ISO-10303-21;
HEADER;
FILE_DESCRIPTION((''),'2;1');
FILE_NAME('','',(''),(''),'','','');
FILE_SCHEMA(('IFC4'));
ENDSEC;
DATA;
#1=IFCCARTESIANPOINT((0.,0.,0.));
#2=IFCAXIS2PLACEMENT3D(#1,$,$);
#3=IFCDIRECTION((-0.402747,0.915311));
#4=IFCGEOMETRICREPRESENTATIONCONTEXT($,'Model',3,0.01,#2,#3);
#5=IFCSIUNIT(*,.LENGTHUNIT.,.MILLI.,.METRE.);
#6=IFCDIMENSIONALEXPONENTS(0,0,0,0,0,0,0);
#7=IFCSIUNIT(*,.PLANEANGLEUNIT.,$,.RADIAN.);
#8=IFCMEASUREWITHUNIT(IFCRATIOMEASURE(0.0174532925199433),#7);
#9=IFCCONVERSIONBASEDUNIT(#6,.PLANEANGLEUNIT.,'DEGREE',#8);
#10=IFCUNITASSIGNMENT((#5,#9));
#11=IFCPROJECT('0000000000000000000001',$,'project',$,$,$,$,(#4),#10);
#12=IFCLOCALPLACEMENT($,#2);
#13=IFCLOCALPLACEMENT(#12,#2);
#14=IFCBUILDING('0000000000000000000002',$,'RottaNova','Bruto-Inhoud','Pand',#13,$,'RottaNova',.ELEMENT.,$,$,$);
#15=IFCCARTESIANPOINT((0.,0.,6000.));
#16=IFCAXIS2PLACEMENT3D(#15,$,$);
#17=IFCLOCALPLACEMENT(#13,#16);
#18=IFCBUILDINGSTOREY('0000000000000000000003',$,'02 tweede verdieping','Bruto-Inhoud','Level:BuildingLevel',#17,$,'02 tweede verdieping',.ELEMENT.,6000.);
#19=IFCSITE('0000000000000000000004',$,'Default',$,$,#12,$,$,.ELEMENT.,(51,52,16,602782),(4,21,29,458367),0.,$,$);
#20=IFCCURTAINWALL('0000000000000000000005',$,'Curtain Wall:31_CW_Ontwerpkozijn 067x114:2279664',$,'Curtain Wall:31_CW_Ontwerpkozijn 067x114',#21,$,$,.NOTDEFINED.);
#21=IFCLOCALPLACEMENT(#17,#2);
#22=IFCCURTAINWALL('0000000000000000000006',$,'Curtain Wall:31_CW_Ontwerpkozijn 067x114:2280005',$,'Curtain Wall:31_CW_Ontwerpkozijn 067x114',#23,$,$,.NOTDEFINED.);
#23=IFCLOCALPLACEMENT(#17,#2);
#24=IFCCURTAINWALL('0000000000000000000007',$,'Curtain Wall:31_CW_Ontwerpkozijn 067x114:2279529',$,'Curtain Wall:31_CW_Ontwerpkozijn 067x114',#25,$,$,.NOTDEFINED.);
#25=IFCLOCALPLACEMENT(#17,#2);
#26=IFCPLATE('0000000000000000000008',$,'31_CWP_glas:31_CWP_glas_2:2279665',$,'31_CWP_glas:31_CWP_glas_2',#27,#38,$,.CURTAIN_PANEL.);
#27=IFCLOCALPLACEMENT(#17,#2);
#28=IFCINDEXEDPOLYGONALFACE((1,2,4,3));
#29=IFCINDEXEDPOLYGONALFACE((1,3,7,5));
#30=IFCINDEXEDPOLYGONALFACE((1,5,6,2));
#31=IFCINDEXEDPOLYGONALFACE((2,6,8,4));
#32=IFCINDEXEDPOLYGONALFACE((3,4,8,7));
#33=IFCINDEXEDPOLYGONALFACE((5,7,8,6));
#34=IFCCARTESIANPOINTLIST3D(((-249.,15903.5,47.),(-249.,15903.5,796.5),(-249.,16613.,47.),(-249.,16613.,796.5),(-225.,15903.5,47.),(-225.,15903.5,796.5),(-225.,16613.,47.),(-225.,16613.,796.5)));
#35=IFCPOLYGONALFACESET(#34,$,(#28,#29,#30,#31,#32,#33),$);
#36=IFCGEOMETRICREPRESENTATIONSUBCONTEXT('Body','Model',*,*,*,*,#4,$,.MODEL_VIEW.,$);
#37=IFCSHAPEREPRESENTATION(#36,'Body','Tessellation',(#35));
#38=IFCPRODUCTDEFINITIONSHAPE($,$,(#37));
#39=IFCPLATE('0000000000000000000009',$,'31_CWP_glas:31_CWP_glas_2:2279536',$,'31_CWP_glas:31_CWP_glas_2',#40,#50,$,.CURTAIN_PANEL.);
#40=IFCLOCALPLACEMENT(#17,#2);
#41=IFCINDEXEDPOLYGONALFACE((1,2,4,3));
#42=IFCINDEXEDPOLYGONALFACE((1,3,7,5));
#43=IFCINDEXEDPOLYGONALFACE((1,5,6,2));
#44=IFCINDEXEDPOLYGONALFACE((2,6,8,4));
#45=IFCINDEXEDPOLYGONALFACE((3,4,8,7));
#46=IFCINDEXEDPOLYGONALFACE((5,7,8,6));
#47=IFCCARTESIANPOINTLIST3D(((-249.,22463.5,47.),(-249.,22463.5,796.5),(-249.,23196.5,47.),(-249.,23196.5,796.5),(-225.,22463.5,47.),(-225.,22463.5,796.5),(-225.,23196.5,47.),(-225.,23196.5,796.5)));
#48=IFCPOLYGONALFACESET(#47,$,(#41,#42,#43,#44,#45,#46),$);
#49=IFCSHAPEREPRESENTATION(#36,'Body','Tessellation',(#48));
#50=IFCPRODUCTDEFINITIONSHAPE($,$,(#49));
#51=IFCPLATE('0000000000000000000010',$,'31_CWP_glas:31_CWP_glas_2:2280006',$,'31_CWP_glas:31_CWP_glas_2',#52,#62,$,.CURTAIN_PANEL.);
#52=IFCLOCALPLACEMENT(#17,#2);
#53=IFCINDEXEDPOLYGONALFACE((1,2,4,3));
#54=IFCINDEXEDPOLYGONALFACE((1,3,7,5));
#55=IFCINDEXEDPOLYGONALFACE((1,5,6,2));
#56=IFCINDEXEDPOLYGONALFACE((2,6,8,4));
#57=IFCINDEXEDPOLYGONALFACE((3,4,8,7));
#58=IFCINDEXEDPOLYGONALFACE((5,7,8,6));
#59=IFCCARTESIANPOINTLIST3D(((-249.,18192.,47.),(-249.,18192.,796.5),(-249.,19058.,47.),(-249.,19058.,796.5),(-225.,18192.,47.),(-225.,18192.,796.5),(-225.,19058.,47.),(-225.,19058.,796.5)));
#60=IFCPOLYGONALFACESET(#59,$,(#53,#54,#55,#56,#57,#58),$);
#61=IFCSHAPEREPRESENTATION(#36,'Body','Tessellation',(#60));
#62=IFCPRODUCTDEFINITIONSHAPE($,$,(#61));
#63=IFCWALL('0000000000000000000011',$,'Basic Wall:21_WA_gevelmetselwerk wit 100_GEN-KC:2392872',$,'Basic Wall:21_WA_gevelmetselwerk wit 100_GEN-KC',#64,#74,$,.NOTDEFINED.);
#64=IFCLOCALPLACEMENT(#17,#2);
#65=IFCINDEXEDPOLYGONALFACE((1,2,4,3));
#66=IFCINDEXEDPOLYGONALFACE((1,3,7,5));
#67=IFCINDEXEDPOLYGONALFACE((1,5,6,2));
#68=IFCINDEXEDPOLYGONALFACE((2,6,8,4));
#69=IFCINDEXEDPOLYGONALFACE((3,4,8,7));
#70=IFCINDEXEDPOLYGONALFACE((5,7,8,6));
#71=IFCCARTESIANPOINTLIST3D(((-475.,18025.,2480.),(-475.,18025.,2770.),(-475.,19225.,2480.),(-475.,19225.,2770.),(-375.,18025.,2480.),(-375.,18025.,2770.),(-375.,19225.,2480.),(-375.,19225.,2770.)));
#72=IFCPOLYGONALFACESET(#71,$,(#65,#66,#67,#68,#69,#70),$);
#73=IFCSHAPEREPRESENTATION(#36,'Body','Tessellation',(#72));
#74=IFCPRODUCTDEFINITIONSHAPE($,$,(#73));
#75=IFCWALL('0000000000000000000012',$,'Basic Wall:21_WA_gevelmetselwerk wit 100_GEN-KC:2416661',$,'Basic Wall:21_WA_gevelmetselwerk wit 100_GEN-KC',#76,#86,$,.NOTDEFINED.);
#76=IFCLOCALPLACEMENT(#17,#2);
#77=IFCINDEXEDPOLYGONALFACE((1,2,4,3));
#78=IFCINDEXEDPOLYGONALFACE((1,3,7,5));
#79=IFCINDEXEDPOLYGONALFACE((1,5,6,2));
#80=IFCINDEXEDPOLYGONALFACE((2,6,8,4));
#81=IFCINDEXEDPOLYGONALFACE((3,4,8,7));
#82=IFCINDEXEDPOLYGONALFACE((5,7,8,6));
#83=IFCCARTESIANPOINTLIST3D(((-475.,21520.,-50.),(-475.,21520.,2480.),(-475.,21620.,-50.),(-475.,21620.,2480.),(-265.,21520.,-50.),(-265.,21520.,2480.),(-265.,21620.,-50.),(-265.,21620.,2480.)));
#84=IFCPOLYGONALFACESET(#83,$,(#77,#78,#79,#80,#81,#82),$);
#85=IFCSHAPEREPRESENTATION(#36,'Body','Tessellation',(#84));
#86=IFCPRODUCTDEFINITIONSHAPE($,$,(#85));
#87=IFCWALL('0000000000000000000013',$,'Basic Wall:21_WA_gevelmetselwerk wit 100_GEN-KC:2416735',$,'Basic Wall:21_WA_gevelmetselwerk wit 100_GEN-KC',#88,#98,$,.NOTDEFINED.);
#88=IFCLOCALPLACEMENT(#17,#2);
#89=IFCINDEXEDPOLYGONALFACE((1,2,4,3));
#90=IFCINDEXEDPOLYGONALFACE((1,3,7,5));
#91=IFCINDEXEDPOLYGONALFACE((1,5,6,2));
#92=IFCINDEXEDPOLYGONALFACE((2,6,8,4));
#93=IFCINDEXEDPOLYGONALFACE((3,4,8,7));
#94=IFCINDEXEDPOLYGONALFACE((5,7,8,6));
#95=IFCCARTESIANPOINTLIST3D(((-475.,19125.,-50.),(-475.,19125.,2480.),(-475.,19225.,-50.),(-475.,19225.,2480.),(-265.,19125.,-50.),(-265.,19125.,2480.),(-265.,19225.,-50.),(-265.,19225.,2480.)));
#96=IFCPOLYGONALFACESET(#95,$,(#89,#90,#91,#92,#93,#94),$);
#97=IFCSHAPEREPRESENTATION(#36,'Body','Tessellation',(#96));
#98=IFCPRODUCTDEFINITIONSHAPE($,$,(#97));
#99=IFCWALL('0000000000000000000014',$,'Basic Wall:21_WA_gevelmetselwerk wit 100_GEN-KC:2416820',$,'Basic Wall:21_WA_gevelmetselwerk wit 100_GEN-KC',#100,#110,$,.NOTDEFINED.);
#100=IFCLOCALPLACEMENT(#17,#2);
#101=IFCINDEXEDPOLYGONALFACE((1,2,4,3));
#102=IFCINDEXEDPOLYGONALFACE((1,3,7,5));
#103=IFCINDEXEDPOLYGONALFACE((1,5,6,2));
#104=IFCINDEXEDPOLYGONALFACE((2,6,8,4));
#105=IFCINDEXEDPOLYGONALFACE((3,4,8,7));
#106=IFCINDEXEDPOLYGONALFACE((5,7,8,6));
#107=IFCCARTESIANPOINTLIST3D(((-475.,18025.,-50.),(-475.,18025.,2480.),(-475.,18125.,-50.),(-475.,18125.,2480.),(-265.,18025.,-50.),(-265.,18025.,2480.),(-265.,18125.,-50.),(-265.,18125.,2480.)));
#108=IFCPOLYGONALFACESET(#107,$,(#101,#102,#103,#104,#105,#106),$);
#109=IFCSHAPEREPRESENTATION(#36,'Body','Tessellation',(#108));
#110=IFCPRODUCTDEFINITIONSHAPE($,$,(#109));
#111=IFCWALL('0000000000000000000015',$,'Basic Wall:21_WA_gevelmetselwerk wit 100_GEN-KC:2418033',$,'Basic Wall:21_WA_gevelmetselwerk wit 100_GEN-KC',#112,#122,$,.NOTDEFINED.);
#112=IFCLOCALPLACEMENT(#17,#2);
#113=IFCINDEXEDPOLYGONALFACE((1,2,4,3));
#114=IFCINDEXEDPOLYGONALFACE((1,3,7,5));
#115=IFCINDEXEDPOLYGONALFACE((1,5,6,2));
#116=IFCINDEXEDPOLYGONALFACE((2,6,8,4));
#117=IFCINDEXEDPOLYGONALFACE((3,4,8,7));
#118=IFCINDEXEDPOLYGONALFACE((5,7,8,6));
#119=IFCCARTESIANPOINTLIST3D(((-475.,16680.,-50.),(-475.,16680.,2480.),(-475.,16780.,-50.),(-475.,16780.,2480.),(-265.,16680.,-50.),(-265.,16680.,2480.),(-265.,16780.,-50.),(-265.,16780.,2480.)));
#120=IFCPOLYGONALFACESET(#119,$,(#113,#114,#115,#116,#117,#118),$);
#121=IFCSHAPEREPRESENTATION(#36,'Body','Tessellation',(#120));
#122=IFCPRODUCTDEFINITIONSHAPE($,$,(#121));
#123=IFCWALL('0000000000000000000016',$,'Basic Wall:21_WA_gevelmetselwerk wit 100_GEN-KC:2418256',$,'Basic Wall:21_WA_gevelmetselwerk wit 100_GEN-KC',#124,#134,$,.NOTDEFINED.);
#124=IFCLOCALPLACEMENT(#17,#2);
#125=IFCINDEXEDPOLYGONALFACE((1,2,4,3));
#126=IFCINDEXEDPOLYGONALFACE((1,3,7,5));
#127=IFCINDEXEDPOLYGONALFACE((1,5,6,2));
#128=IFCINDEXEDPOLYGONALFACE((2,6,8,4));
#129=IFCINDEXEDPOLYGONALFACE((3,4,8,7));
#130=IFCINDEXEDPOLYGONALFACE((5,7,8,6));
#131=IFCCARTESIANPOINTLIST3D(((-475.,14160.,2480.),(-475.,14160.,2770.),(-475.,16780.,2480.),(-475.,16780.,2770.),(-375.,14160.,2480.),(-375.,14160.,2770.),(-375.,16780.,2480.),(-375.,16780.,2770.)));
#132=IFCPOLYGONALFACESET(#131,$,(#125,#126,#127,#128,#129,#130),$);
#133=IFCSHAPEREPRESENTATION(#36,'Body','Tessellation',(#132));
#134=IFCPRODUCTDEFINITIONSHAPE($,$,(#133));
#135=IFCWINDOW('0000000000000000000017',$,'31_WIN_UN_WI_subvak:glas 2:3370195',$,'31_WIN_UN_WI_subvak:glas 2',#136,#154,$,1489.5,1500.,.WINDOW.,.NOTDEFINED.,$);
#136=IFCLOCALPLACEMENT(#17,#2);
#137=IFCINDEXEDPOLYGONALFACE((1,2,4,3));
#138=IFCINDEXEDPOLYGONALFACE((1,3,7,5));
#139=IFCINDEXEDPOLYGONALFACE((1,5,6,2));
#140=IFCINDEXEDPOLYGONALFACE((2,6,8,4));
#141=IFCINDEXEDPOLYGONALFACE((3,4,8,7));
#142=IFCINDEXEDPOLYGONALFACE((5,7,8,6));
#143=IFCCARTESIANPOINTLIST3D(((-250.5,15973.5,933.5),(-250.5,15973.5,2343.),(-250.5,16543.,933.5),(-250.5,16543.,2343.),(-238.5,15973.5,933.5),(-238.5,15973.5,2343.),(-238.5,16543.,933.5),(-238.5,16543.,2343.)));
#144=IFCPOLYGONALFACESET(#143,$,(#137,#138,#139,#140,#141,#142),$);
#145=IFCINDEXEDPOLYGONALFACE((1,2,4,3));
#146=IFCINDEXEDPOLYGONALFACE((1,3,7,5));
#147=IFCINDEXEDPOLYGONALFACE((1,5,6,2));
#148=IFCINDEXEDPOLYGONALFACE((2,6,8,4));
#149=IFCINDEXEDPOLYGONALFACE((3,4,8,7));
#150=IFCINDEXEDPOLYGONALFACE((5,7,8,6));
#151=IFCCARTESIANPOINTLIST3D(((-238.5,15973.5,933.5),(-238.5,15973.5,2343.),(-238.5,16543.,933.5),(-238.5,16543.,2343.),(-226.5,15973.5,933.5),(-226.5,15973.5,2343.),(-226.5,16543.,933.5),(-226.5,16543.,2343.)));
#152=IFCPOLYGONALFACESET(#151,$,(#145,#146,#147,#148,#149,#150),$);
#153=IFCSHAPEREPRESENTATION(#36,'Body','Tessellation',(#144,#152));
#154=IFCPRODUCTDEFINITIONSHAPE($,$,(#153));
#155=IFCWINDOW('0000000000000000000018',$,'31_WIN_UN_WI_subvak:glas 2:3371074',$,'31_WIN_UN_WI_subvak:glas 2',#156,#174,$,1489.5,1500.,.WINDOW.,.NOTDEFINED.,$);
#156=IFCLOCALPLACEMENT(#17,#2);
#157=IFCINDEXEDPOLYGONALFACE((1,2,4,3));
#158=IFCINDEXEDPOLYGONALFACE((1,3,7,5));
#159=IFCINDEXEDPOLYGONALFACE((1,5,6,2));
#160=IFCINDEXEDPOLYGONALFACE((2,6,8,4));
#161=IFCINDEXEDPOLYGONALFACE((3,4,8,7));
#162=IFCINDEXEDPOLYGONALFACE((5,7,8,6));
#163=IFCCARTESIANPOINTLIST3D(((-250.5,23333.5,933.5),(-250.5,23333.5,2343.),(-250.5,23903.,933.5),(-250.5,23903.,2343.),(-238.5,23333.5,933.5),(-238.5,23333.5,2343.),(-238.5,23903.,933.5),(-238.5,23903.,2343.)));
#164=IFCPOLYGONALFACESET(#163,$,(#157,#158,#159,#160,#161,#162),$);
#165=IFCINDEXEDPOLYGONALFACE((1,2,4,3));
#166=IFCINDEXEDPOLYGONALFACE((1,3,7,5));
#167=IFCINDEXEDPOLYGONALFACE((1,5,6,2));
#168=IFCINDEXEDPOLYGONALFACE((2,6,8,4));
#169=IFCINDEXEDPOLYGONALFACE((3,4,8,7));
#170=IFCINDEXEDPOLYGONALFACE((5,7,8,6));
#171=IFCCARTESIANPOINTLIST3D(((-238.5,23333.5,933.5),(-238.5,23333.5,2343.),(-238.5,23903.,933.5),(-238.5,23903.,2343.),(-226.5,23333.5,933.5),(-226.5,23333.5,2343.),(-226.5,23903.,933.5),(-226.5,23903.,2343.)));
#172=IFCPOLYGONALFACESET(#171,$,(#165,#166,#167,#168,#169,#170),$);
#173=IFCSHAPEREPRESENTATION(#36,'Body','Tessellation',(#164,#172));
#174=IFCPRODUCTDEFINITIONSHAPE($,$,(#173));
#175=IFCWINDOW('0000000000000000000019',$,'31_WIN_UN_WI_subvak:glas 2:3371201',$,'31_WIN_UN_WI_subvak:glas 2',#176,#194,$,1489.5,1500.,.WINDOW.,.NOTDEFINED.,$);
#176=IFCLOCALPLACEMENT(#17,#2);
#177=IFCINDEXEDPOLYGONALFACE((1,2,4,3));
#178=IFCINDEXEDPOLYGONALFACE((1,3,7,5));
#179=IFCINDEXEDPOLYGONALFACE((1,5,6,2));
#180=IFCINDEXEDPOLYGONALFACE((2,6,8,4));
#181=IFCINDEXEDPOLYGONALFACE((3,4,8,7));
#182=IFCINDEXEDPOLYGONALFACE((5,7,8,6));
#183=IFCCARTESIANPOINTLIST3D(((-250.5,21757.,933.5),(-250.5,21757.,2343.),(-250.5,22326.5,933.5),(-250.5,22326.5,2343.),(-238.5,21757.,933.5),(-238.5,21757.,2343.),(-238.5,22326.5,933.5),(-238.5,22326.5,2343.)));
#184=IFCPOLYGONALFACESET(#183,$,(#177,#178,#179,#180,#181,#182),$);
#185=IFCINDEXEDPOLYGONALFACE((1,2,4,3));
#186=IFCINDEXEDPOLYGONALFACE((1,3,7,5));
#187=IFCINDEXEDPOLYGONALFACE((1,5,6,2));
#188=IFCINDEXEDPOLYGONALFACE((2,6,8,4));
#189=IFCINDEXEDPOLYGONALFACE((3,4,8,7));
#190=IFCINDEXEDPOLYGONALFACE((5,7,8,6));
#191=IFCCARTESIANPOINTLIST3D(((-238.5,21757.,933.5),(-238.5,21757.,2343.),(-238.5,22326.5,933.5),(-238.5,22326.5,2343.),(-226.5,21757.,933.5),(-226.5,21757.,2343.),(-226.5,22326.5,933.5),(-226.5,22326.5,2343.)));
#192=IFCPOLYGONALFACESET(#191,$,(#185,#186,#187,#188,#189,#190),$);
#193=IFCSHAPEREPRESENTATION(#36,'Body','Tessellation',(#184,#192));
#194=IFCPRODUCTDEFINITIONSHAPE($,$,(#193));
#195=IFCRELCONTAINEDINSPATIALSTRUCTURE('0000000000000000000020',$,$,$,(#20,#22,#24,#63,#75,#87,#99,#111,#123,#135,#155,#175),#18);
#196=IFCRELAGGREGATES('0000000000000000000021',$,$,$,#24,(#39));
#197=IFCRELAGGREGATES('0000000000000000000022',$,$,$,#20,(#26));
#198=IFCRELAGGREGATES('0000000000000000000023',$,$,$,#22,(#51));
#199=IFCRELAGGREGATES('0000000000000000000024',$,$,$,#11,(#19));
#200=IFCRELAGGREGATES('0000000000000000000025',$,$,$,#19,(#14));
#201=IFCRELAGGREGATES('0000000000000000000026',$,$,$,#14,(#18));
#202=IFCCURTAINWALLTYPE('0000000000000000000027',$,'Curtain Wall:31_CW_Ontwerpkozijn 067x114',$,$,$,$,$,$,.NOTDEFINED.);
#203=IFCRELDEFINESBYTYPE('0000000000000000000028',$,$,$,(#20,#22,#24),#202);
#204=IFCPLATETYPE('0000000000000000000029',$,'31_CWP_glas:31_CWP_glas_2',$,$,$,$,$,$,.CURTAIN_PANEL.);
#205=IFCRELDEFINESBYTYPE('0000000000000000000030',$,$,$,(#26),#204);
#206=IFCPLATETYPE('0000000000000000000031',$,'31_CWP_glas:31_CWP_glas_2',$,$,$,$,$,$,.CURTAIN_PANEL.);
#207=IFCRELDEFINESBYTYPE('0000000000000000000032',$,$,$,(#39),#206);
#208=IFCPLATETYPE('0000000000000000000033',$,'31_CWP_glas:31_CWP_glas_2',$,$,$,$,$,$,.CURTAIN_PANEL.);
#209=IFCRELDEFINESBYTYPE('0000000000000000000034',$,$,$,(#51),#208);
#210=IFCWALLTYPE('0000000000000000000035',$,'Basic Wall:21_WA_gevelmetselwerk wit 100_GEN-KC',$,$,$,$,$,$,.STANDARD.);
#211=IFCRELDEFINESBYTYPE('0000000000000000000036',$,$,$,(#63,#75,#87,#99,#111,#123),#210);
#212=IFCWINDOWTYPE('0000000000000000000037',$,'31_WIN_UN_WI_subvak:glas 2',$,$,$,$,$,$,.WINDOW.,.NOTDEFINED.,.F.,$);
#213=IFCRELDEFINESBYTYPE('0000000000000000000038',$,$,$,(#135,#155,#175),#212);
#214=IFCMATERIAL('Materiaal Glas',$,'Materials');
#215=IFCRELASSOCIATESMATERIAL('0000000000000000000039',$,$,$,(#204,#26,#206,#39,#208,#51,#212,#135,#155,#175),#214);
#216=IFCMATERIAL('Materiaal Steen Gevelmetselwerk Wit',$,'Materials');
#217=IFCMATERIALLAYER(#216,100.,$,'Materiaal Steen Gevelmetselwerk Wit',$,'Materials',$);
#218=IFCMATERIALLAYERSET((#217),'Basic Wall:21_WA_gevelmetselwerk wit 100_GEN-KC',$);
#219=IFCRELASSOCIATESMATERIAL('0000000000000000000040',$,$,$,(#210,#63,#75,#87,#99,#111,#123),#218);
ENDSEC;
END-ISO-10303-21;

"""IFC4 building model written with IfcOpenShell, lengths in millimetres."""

from ifc_helpers import new_model, entity, si_unit, converted_unit, direction, frame, frame_2d, origin, origin_2d_with_axis, place, context, subcontext, project, spatial, rectangle, extrude, source, transform, mapped, material, layer, layer_set, type_object, type_shapes, element, aggregate, save


model = new_model("IFC4")

# Units and contexts
model_context = context("Model", 3, precision=0.01, world=origin(), true_north=direction((-0.402747, 0.915311)))
body_context = subcontext(model_context, "Body", "Model", "MODEL_VIEW")
ifc_project = project(units=[si_unit("LENGTHUNIT", "METRE", prefix="MILLI"), converted_unit("PLANEANGLEUNIT", "DEGREE", entity("IfcRatioMeasure", 0.0174532925199433), si_unit("PLANEANGLEUNIT", "RADIAN"), dimensions=[0, 0, 0, 0, 0, 0, 0])], contexts=[model_context])

# Site, building, storey
site_placement = place(None, origin())
site = spatial("IfcSite", under=ifc_project, at=site_placement, Name="Default", CompositionType="ELEMENT", RefLatitude=(51, 52, 16, 602782), RefLongitude=(4, 21, 29, 458367), RefElevation=0.0)
building_placement = place(site_placement, origin())
building = spatial("IfcBuilding", under=site, at=building_placement, Name="RottaNova", Description="Bruto-Inhoud", ObjectType="Pand", LongName="RottaNova", CompositionType="ELEMENT")
storey_placement = place(building_placement, frame((0.0, 0.0, 6000.0)))
storey = spatial("IfcBuildingStorey", under=building, at=storey_placement, Name="02 tweede verdieping", Description="Bruto-Inhoud", ObjectType="Level:BuildingLevel", LongName="02 tweede verdieping", CompositionType="ELEMENT", Elevation=6000.0)

# Curtain walls
curtain_wall_type = type_object("IfcCurtainWallType", Name="Curtain Wall:31_CW_Ontwerpkozijn 067x114", PredefinedType="NOTDEFINED")
curtain_wall_1_placement = place(storey_placement, frame((0.0, 0.0, -6000.0)))
curtain_wall_1 = element("IfcCurtainWall", 1, at=curtain_wall_1_placement, inside=storey, type_object=curtain_wall_type, Name="Curtain Wall:31_CW_Ontwerpkozijn 067x114:2279664", ObjectType="Curtain Wall:31_CW_Ontwerpkozijn 067x114", PredefinedType="NOTDEFINED")
curtain_wall_2_placement = place(storey_placement, frame((0.0, 0.0, -6000.0)))
curtain_wall_2 = element("IfcCurtainWall", 2, at=curtain_wall_2_placement, inside=storey, type_object=curtain_wall_type, Name="Curtain Wall:31_CW_Ontwerpkozijn 067x114:2280005", ObjectType="Curtain Wall:31_CW_Ontwerpkozijn 067x114", PredefinedType="NOTDEFINED")

# Curtain wall
curtain_wall_3_placement = place(storey_placement, frame((0.0, 0.0, -6000.0)))
curtain_wall_3 = element("IfcCurtainWall", 3, at=curtain_wall_3_placement, inside=storey, type_object=curtain_wall_type, Name="Curtain Wall:31_CW_Ontwerpkozijn 067x114:2279529", ObjectType="Curtain Wall:31_CW_Ontwerpkozijn 067x114", PredefinedType="NOTDEFINED")
ifc_material_1 = material(Name="Materiaal Glas", Category="Materials")
plate_type_1 = type_object("IfcPlateType", Name="31_CWP_glas:31_CWP_glas_2", PredefinedType="CURTAIN_PANEL", material=ifc_material_1)
shared_shape_1 = source(origin(), body_context, "Body", "SweptSolid", [
    extrude(rectangle(XDim=24.0, YDim=709.5, at=frame_2d((0.0, 0.0), x_axis=(1.0, 0.0))), frame((354.8, 12.0, 0.0), z_axis=(0.0, 0.0, 1.0), x_axis=(0.0, 1.0, 0.0)), (0.0, 0.0, 1.0), 749.5),
])
type_shapes(plate_type_1, [shared_shape_1])

# Plates
plate_1_placement = place(curtain_wall_1_placement, frame((-249.0, 16613.0, 6047.0), z_axis=(0.0, 0.0, 1.0), x_axis=(0.0, -1.0, 0.0)))
plate_1 = element("IfcPlate", 4, at=plate_1_placement, type_object=plate_type_1, material=ifc_material_1, Name="31_CWP_glas:31_CWP_glas_2:2279665", ObjectType="31_CWP_glas:31_CWP_glas_2", PredefinedType="CURTAIN_PANEL", context=body_context, shape_type="MappedRepresentation", body=[
    mapped(shared_shape_1, transform((0.0, 0.0, 0.0), scale=1.0)),
])
plate_type_2 = type_object("IfcPlateType", Name="31_CWP_glas:31_CWP_glas_2", PredefinedType="CURTAIN_PANEL", material=ifc_material_1)
shared_shape_2 = source(origin(), body_context, "Body", "SweptSolid", [
    extrude(rectangle(XDim=24.0, YDim=733.0, at=frame_2d((0.0, 0.0), x_axis=(1.0, 0.0))), frame((366.5, 12.0, 0.0), z_axis=(0.0, 0.0, 1.0), x_axis=(0.0, 1.0, 0.0)), (0.0, 0.0, 1.0), 749.5),
])
type_shapes(plate_type_2, [shared_shape_2])
plate_2_placement = place(curtain_wall_3_placement, frame((-249.0, 23196.5, 6047.0), z_axis=(0.0, 0.0, 1.0), x_axis=(0.0, -1.0, 0.0)))
plate_2 = element("IfcPlate", 5, at=plate_2_placement, type_object=plate_type_2, material=ifc_material_1, Name="31_CWP_glas:31_CWP_glas_2:2279536", ObjectType="31_CWP_glas:31_CWP_glas_2", PredefinedType="CURTAIN_PANEL", context=body_context, shape_type="MappedRepresentation", body=[
    mapped(shared_shape_2, transform((0.0, 0.0, 0.0), scale=1.0)),
])
aggregate(curtain_wall_3, [plate_2])
plate_type_3 = type_object("IfcPlateType", Name="31_CWP_glas:31_CWP_glas_2", PredefinedType="CURTAIN_PANEL", material=ifc_material_1)
shared_shape_3 = source(origin(), body_context, "Body", "SweptSolid", [
    extrude(rectangle(XDim=24.0, YDim=866.0, at=frame_2d((0.0, 0.0), x_axis=(1.0, 0.0))), frame((433.0, 12.0, 0.0), z_axis=(0.0, 0.0, 1.0), x_axis=(0.0, 1.0, 0.0)), (0.0, 0.0, 1.0), 749.5),
])
type_shapes(plate_type_3, [shared_shape_3])
plate_3_placement = place(curtain_wall_2_placement, frame((-225.0, 18192.0, 6047.0), z_axis=(0.0, 0.0, 1.0), x_axis=(0.0, 1.0, 0.0)))
plate_3 = element("IfcPlate", 6, at=plate_3_placement, type_object=plate_type_3, material=ifc_material_1, Name="31_CWP_glas:31_CWP_glas_2:2280006", ObjectType="31_CWP_glas:31_CWP_glas_2", PredefinedType="CURTAIN_PANEL", context=body_context, shape_type="MappedRepresentation", body=[
    mapped(shared_shape_3, transform((0.0, 0.0, 0.0), scale=1.0)),
])

# Shared definitions
ifc_material_2 = material(Name="Materiaal Steen Gevelmetselwerk Wit", Category="Materials")
ifc_layer = layer(ifc_material_2, 100.0, Name="Materiaal Steen Gevelmetselwerk Wit", Category="Materials")
ifc_layer_set = layer_set([ifc_layer], Name="Basic Wall:21_WA_gevelmetselwerk wit 100_GEN-KC")
wall_type = type_object("IfcWallType", Name="Basic Wall:21_WA_gevelmetselwerk wit 100_GEN-KC", PredefinedType="STANDARD", material=ifc_layer_set)

# Walls
wall_1_placement = place(storey_placement, frame((-425.0, 19225.0, 2480.0), z_axis=(0.0, 0.0, 1.0), x_axis=(0.0, -1.0, 0.0)))
element("IfcWall", 7, at=wall_1_placement, inside=storey, type_object=wall_type, material=ifc_layer_set, Name="Basic Wall:21_WA_gevelmetselwerk wit 100_GEN-KC:2392872", ObjectType="Basic Wall:21_WA_gevelmetselwerk wit 100_GEN-KC", PredefinedType="NOTDEFINED", context=body_context, shape_type="SweptSolid", body=[
    extrude(rectangle(XDim=1200.0, YDim=100.0, at=frame_2d((600.0, 0.0), x_axis=(-1.0, 0.0))), origin(), (0.0, 0.0, 1.0), 290.0),
])
wall_2_placement = place(storey_placement, frame((-265.0, 21570.0, -50.0), z_axis=(0.0, 0.0, 1.0), x_axis=(-1.0, 0.0, 0.0)))
element("IfcWall", 8, at=wall_2_placement, inside=storey, type_object=wall_type, material=ifc_layer_set, Name="Basic Wall:21_WA_gevelmetselwerk wit 100_GEN-KC:2416661", ObjectType="Basic Wall:21_WA_gevelmetselwerk wit 100_GEN-KC", PredefinedType="NOTDEFINED", context=body_context, shape_type="SweptSolid", body=[
    extrude(rectangle(XDim=210.0, YDim=100.0, at=frame_2d((105.0, 0.0), x_axis=(-1.0, 0.0))), origin(), (0.0, 0.0, 1.0), 2530.0),
])
wall_3_placement = place(storey_placement, frame((-265.0, 19175.0, -50.0), z_axis=(0.0, 0.0, 1.0), x_axis=(-1.0, 0.0, 0.0)))
element("IfcWall", 9, at=wall_3_placement, inside=storey, type_object=wall_type, material=ifc_layer_set, Name="Basic Wall:21_WA_gevelmetselwerk wit 100_GEN-KC:2416735", ObjectType="Basic Wall:21_WA_gevelmetselwerk wit 100_GEN-KC", PredefinedType="NOTDEFINED", context=body_context, shape_type="SweptSolid", body=[
    extrude(rectangle(XDim=210.0, YDim=100.0, at=frame_2d((105.0, 0.0), x_axis=(-1.0, 0.0))), origin(), (0.0, 0.0, 1.0), 2530.0),
])
wall_4_placement = place(storey_placement, frame((-265.0, 18075.0, -50.0), z_axis=(0.0, 0.0, 1.0), x_axis=(-1.0, 0.0, 0.0)))
element("IfcWall", 10, at=wall_4_placement, inside=storey, type_object=wall_type, material=ifc_layer_set, Name="Basic Wall:21_WA_gevelmetselwerk wit 100_GEN-KC:2416820", ObjectType="Basic Wall:21_WA_gevelmetselwerk wit 100_GEN-KC", PredefinedType="NOTDEFINED", context=body_context, shape_type="SweptSolid", body=[
    extrude(rectangle(XDim=210.0, YDim=100.0, at=frame_2d((105.0, 0.0), x_axis=(-1.0, 0.0))), origin(), (0.0, 0.0, 1.0), 2530.0),
])
wall_5_placement = place(storey_placement, frame((-265.0, 16730.0, -50.0), z_axis=(0.0, 0.0, 1.0), x_axis=(-1.0, 0.0, 0.0)))
element("IfcWall", 11, at=wall_5_placement, inside=storey, type_object=wall_type, material=ifc_layer_set, Name="Basic Wall:21_WA_gevelmetselwerk wit 100_GEN-KC:2418033", ObjectType="Basic Wall:21_WA_gevelmetselwerk wit 100_GEN-KC", PredefinedType="NOTDEFINED", context=body_context, shape_type="SweptSolid", body=[
    extrude(rectangle(XDim=210.0, YDim=100.0, at=frame_2d((105.0, 0.0), x_axis=(-1.0, 0.0))), origin(), (0.0, 0.0, 1.0), 2530.0),
])
wall_6_placement = place(storey_placement, frame((-425.0, 16780.0, 2480.0), z_axis=(0.0, 0.0, 1.0), x_axis=(0.0, -1.0, 0.0)))
element("IfcWall", 12, at=wall_6_placement, inside=storey, type_object=wall_type, material=ifc_layer_set, Name="Basic Wall:21_WA_gevelmetselwerk wit 100_GEN-KC:2418256", ObjectType="Basic Wall:21_WA_gevelmetselwerk wit 100_GEN-KC", PredefinedType="NOTDEFINED", context=body_context, shape_type="SweptSolid", body=[
    extrude(rectangle(XDim=2620.0, YDim=100.0, at=frame_2d((1310.0, 0.0), x_axis=(-1.0, 0.0))), origin(), (0.0, 0.0, 1.0), 290.0),
])

# Windows
window_type_1 = type_object("IfcWindowType", Name="31_WIN_UN_WI_subvak:glas 2", ParameterTakesPrecedence=False, PartitioningType="NOTDEFINED", PredefinedType="WINDOW", material=ifc_material_1)
shared_shape_4 = source(origin(), body_context, "Body", "SweptSolid", [
    extrude(rectangle(XDim=569.5, YDim=12.0, at=origin_2d_with_axis()), frame((0.0, -6.0, 0.0)), (0.0, 0.0, 1.0), 1409.5),
    extrude(rectangle(XDim=569.5, YDim=12.0, at=origin_2d_with_axis()), frame((0.0, 6.0, 0.0)), (0.0, 0.0, 1.0), 1409.5),
])
type_shapes(window_type_1, [shared_shape_4])
for number, where, z_axis, x_axis, name in (
    (13, (-238.5, 16258.3, 933.5), (0.0, 0.0, 1.0), (0.0, -1.0, 0.0), "31_WIN_UN_WI_subvak:glas 2:3370195"),
    (14, (-238.5, 23618.2, 933.5), (0.0, 0.0, 1.0), (0.0, -1.0, 0.0), "31_WIN_UN_WI_subvak:glas 2:3371074"),
    (15, (-238.5, 22041.7, 933.5), (0.0, 0.0, 1.0), (0.0, -1.0, 0.0), "31_WIN_UN_WI_subvak:glas 2:3371201"),
):
    element("IfcWindow", number, at=place(storey_placement, frame(where, z_axis=z_axis, x_axis=x_axis)), inside=storey, type_object=window_type_1, material=ifc_material_1, Name=name, ObjectType="31_WIN_UN_WI_subvak:glas 2", OverallHeight=1489.5, OverallWidth=1500.0, PartitioningType="NOTDEFINED", PredefinedType="WINDOW", context=body_context, shape_type="MappedRepresentation", body=[
        mapped(shared_shape_4, transform((0.0, 0.0, 0.0), scale=1.0)),
    ])

aggregate(curtain_wall_1, [plate_1])
aggregate(curtain_wall_2, [plate_3])

save(model, "model.ifc")
